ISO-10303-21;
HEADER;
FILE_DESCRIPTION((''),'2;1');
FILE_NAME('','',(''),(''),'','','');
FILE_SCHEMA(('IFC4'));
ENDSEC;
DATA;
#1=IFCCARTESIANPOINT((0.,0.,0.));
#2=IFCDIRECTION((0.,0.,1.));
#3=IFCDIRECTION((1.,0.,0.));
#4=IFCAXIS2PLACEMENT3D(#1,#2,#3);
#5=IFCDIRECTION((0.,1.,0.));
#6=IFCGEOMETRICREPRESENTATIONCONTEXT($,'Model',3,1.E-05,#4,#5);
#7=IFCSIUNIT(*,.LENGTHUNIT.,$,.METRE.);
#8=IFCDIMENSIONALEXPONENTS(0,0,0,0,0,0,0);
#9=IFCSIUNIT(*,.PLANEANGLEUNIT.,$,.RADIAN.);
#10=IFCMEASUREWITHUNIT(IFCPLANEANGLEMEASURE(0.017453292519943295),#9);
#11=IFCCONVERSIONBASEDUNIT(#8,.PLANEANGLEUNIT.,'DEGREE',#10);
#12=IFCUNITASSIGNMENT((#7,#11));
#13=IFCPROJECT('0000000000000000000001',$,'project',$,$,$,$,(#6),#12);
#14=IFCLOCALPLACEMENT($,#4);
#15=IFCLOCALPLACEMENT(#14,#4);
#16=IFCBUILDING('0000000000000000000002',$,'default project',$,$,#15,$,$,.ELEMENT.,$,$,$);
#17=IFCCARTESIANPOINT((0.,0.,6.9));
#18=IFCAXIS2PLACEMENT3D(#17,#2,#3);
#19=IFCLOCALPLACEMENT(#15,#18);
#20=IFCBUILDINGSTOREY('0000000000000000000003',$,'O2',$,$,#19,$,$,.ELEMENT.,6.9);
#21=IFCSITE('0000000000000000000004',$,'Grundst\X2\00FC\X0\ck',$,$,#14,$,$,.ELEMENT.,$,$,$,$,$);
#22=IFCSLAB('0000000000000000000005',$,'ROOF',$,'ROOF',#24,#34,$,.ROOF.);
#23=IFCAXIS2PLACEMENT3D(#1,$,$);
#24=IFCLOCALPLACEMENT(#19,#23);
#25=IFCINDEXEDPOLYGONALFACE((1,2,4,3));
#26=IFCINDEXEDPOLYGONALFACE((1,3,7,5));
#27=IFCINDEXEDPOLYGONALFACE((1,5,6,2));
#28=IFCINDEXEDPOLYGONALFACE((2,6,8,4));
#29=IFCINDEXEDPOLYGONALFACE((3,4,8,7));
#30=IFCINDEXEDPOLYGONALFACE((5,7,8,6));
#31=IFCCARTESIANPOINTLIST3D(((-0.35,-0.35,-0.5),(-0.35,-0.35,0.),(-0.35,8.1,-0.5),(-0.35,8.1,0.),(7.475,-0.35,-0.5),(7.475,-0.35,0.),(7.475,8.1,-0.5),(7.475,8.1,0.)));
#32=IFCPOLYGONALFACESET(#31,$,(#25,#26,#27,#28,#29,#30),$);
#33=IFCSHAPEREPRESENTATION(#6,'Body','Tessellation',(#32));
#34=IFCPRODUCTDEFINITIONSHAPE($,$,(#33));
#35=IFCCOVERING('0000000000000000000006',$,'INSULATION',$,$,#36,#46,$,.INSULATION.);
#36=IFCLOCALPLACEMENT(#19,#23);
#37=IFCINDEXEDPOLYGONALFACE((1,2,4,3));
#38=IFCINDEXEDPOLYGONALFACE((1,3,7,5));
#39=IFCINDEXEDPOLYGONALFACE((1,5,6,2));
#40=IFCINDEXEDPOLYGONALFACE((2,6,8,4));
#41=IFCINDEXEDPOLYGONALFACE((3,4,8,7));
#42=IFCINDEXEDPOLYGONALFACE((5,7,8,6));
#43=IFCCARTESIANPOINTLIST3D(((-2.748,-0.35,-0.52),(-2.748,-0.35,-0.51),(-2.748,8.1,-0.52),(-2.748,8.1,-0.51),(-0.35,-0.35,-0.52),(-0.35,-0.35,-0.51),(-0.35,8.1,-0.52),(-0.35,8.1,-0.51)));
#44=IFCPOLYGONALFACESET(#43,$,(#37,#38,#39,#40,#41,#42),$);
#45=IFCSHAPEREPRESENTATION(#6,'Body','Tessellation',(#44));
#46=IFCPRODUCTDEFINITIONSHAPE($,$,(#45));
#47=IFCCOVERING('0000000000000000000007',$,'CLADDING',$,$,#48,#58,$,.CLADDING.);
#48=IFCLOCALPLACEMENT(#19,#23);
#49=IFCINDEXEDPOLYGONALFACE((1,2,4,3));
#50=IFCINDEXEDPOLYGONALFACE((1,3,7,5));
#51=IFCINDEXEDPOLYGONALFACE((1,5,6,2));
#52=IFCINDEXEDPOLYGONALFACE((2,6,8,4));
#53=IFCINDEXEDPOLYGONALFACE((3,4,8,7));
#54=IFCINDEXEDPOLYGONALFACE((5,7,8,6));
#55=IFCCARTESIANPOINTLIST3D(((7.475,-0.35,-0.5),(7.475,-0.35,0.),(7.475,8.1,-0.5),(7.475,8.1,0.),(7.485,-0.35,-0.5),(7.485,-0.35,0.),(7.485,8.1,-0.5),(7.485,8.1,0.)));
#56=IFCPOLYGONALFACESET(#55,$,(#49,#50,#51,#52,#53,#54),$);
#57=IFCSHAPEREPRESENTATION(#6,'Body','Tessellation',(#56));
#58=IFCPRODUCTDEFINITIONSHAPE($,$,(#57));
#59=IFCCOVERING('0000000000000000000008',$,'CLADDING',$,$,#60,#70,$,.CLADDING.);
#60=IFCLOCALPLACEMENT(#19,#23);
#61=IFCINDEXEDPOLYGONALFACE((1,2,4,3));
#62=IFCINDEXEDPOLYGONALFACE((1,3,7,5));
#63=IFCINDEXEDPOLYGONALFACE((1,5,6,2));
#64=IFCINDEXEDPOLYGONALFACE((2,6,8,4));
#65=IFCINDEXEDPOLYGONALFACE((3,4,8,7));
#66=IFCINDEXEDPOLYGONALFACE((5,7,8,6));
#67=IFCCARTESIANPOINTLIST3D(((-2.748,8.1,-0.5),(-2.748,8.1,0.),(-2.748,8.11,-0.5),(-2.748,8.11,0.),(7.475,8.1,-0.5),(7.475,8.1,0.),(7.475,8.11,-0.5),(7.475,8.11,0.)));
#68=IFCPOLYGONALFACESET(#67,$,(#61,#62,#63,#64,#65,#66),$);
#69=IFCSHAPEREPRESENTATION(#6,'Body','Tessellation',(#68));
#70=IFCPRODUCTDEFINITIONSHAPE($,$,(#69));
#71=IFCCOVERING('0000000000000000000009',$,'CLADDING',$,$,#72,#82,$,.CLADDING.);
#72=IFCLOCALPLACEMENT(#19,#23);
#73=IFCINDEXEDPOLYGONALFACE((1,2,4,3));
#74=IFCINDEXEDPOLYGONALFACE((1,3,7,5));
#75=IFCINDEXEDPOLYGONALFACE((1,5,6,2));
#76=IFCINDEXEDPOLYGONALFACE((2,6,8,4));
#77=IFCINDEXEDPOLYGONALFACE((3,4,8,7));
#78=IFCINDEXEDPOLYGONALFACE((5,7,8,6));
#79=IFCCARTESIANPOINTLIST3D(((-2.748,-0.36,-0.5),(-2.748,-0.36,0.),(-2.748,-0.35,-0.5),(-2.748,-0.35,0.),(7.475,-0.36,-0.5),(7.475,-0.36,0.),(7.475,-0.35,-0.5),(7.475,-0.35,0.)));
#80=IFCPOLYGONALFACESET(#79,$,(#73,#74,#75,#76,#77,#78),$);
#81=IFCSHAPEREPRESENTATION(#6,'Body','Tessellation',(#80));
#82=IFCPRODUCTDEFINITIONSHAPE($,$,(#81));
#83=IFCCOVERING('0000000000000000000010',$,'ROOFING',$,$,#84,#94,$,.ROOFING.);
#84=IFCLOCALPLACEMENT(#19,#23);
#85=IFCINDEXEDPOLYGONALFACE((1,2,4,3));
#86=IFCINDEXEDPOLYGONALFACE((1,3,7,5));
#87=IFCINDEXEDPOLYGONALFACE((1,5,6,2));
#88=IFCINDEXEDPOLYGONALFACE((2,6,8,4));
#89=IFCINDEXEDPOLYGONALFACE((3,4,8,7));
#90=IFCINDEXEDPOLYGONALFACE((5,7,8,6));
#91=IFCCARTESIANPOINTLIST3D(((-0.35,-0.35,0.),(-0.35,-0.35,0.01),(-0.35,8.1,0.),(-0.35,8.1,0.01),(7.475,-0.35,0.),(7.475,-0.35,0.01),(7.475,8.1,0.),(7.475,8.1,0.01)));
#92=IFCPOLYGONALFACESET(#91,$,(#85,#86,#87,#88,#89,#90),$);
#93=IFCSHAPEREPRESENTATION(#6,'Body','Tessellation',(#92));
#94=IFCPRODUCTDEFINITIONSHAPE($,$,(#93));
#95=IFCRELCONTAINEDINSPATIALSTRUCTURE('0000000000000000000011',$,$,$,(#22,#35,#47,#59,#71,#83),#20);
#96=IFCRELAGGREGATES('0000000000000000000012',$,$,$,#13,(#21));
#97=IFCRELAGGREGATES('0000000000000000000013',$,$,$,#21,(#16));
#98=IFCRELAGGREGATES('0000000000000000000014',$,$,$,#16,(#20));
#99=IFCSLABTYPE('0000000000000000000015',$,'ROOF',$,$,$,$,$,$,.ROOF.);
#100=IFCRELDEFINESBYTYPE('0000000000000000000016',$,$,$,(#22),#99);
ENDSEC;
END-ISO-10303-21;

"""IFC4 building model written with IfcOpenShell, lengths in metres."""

from ifc_helpers import new_model, entity, si_unit, converted_unit, direction, frame, origin_with_axes, place, context, project, spatial, polyline, outline, extrude, type_object, element, save


model = new_model("IFC4")

# Units and contexts
model_context = context("Model", 3, precision=1e-05, world=origin_with_axes(), true_north=direction((0.0, 1.0, 0.0)))
ifc_project = project(units=[si_unit("LENGTHUNIT", "METRE"), converted_unit("PLANEANGLEUNIT", "DEGREE", entity("IfcPlaneAngleMeasure", 0.017453292519943295), si_unit("PLANEANGLEUNIT", "RADIAN"), dimensions=[0, 0, 0, 0, 0, 0, 0])], contexts=[model_context])

# Site, building, storey
site_placement = place(None, origin_with_axes())
site = spatial("IfcSite", under=ifc_project, at=site_placement, Name="Grundstück", CompositionType="ELEMENT")
building_placement = place(site_placement, origin_with_axes())
building = spatial("IfcBuilding", under=site, at=building_placement, Name="default project", CompositionType="ELEMENT")
storey_placement = place(building_placement, frame((0.0, 0.0, 6.9), z_axis=(0.0, 0.0, 1.0), x_axis=(1.0, 0.0, 0.0)))
storey = spatial("IfcBuildingStorey", under=building, at=storey_placement, Name="O2", CompositionType="ELEMENT", Elevation=6.9)

# Slab
slab_type = type_object("IfcSlabType", Name="ROOF", PredefinedType="ROOF")
slab_placement = place(storey_placement, frame((0.0, 0.0, -0.5), z_axis=(0.0, 0.0, 1.0), x_axis=(1.0, 0.0, 0.0)))
element("IfcSlab", 1, at=slab_placement, inside=storey, type_object=slab_type, Name="ROOF", ObjectType="ROOF", PredefinedType="ROOF", context=model_context, shape_type="SweptSolid", body=[
    extrude(outline(polyline([(7.475, 8.1), (-0.35, 8.1), (-0.35, -0.35), (7.475, -0.35), (7.475, 8.1)])), origin_with_axes(), (0.0, 0.0, 1.0), 0.5),
])

# Coverings
placement = place(storey_placement, frame((0.0, 0.0, -0.5), z_axis=(0.0, 0.0, 1.0), x_axis=(1.0, 0.0, 0.0)))
covering_1_placement = place(placement, frame((0.0, 0.0, -0.01), z_axis=(0.0, 0.0, 1.0), x_axis=(1.0, 0.0, 0.0)))
element("IfcCovering", 2, at=covering_1_placement, inside=storey, Name="INSULATION", PredefinedType="INSULATION", context=model_context, shape_type="SweptSolid", body=[
    extrude(outline(polyline([(-0.35, 8.1), (-2.748, 8.1), (-2.748, -0.35), (-0.35, -0.35), (-0.35, 8.1)])), frame((0.0, 0.0, -0.01), z_axis=(0.0, 0.0, 1.0), x_axis=(1.0, 0.0, 0.0)), (0.0, 0.0, 1.0), 0.01),
])
covering_2_placement = place(slab_placement, origin_with_axes())
element("IfcCovering", 3, at=covering_2_placement, inside=storey, Name="CLADDING", PredefinedType="CLADDING", context=model_context, shape_type="SweptSolid", body=[
    extrude(outline(polyline([(7.485, -0.35), (7.485, 8.1), (7.475, 8.1), (7.475, -0.35), (7.485, -0.35)])), origin_with_axes(), (0.0, 0.0, 1.0), 0.5),
])
covering_3_placement = place(slab_placement, origin_with_axes())
element("IfcCovering", 4, at=covering_3_placement, inside=storey, Name="CLADDING", PredefinedType="CLADDING", context=model_context, shape_type="SweptSolid", body=[
    extrude(outline(polyline([(7.475, 8.11), (-2.748, 8.11), (-2.748, 8.1), (7.475, 8.1), (7.475, 8.11)])), origin_with_axes(), (0.0, 0.0, 1.0), 0.5),
])
covering_4_placement = place(slab_placement, origin_with_axes())
element("IfcCovering", 5, at=covering_4_placement, inside=storey, Name="CLADDING", PredefinedType="CLADDING", context=model_context, shape_type="SweptSolid", body=[
    extrude(outline(polyline([(-2.748, -0.36), (7.475, -0.36), (7.475, -0.35), (-2.748, -0.35), (-2.748, -0.36)])), origin_with_axes(), (0.0, 0.0, 1.0), 0.5),
])
covering_5_placement = place(slab_placement, frame((0.0, 0.0, 0.25), z_axis=(0.0, 0.0, 1.0), x_axis=(1.0, 0.0, 0.0)))
element("IfcCovering", 6, at=covering_5_placement, inside=storey, Name="ROOFING", PredefinedType="ROOFING", context=model_context, shape_type="SweptSolid", body=[
    extrude(outline(polyline([(7.475, 8.1), (-0.35, 8.1), (-0.35, -0.35), (7.475, -0.35), (7.475, 8.1)])), frame((0.0, 0.0, 0.25), z_axis=(0.0, 0.0, 1.0), x_axis=(1.0, 0.0, 0.0)), (0.0, 0.0, 1.0), 0.01),
])

save(model, "model.ifc")
